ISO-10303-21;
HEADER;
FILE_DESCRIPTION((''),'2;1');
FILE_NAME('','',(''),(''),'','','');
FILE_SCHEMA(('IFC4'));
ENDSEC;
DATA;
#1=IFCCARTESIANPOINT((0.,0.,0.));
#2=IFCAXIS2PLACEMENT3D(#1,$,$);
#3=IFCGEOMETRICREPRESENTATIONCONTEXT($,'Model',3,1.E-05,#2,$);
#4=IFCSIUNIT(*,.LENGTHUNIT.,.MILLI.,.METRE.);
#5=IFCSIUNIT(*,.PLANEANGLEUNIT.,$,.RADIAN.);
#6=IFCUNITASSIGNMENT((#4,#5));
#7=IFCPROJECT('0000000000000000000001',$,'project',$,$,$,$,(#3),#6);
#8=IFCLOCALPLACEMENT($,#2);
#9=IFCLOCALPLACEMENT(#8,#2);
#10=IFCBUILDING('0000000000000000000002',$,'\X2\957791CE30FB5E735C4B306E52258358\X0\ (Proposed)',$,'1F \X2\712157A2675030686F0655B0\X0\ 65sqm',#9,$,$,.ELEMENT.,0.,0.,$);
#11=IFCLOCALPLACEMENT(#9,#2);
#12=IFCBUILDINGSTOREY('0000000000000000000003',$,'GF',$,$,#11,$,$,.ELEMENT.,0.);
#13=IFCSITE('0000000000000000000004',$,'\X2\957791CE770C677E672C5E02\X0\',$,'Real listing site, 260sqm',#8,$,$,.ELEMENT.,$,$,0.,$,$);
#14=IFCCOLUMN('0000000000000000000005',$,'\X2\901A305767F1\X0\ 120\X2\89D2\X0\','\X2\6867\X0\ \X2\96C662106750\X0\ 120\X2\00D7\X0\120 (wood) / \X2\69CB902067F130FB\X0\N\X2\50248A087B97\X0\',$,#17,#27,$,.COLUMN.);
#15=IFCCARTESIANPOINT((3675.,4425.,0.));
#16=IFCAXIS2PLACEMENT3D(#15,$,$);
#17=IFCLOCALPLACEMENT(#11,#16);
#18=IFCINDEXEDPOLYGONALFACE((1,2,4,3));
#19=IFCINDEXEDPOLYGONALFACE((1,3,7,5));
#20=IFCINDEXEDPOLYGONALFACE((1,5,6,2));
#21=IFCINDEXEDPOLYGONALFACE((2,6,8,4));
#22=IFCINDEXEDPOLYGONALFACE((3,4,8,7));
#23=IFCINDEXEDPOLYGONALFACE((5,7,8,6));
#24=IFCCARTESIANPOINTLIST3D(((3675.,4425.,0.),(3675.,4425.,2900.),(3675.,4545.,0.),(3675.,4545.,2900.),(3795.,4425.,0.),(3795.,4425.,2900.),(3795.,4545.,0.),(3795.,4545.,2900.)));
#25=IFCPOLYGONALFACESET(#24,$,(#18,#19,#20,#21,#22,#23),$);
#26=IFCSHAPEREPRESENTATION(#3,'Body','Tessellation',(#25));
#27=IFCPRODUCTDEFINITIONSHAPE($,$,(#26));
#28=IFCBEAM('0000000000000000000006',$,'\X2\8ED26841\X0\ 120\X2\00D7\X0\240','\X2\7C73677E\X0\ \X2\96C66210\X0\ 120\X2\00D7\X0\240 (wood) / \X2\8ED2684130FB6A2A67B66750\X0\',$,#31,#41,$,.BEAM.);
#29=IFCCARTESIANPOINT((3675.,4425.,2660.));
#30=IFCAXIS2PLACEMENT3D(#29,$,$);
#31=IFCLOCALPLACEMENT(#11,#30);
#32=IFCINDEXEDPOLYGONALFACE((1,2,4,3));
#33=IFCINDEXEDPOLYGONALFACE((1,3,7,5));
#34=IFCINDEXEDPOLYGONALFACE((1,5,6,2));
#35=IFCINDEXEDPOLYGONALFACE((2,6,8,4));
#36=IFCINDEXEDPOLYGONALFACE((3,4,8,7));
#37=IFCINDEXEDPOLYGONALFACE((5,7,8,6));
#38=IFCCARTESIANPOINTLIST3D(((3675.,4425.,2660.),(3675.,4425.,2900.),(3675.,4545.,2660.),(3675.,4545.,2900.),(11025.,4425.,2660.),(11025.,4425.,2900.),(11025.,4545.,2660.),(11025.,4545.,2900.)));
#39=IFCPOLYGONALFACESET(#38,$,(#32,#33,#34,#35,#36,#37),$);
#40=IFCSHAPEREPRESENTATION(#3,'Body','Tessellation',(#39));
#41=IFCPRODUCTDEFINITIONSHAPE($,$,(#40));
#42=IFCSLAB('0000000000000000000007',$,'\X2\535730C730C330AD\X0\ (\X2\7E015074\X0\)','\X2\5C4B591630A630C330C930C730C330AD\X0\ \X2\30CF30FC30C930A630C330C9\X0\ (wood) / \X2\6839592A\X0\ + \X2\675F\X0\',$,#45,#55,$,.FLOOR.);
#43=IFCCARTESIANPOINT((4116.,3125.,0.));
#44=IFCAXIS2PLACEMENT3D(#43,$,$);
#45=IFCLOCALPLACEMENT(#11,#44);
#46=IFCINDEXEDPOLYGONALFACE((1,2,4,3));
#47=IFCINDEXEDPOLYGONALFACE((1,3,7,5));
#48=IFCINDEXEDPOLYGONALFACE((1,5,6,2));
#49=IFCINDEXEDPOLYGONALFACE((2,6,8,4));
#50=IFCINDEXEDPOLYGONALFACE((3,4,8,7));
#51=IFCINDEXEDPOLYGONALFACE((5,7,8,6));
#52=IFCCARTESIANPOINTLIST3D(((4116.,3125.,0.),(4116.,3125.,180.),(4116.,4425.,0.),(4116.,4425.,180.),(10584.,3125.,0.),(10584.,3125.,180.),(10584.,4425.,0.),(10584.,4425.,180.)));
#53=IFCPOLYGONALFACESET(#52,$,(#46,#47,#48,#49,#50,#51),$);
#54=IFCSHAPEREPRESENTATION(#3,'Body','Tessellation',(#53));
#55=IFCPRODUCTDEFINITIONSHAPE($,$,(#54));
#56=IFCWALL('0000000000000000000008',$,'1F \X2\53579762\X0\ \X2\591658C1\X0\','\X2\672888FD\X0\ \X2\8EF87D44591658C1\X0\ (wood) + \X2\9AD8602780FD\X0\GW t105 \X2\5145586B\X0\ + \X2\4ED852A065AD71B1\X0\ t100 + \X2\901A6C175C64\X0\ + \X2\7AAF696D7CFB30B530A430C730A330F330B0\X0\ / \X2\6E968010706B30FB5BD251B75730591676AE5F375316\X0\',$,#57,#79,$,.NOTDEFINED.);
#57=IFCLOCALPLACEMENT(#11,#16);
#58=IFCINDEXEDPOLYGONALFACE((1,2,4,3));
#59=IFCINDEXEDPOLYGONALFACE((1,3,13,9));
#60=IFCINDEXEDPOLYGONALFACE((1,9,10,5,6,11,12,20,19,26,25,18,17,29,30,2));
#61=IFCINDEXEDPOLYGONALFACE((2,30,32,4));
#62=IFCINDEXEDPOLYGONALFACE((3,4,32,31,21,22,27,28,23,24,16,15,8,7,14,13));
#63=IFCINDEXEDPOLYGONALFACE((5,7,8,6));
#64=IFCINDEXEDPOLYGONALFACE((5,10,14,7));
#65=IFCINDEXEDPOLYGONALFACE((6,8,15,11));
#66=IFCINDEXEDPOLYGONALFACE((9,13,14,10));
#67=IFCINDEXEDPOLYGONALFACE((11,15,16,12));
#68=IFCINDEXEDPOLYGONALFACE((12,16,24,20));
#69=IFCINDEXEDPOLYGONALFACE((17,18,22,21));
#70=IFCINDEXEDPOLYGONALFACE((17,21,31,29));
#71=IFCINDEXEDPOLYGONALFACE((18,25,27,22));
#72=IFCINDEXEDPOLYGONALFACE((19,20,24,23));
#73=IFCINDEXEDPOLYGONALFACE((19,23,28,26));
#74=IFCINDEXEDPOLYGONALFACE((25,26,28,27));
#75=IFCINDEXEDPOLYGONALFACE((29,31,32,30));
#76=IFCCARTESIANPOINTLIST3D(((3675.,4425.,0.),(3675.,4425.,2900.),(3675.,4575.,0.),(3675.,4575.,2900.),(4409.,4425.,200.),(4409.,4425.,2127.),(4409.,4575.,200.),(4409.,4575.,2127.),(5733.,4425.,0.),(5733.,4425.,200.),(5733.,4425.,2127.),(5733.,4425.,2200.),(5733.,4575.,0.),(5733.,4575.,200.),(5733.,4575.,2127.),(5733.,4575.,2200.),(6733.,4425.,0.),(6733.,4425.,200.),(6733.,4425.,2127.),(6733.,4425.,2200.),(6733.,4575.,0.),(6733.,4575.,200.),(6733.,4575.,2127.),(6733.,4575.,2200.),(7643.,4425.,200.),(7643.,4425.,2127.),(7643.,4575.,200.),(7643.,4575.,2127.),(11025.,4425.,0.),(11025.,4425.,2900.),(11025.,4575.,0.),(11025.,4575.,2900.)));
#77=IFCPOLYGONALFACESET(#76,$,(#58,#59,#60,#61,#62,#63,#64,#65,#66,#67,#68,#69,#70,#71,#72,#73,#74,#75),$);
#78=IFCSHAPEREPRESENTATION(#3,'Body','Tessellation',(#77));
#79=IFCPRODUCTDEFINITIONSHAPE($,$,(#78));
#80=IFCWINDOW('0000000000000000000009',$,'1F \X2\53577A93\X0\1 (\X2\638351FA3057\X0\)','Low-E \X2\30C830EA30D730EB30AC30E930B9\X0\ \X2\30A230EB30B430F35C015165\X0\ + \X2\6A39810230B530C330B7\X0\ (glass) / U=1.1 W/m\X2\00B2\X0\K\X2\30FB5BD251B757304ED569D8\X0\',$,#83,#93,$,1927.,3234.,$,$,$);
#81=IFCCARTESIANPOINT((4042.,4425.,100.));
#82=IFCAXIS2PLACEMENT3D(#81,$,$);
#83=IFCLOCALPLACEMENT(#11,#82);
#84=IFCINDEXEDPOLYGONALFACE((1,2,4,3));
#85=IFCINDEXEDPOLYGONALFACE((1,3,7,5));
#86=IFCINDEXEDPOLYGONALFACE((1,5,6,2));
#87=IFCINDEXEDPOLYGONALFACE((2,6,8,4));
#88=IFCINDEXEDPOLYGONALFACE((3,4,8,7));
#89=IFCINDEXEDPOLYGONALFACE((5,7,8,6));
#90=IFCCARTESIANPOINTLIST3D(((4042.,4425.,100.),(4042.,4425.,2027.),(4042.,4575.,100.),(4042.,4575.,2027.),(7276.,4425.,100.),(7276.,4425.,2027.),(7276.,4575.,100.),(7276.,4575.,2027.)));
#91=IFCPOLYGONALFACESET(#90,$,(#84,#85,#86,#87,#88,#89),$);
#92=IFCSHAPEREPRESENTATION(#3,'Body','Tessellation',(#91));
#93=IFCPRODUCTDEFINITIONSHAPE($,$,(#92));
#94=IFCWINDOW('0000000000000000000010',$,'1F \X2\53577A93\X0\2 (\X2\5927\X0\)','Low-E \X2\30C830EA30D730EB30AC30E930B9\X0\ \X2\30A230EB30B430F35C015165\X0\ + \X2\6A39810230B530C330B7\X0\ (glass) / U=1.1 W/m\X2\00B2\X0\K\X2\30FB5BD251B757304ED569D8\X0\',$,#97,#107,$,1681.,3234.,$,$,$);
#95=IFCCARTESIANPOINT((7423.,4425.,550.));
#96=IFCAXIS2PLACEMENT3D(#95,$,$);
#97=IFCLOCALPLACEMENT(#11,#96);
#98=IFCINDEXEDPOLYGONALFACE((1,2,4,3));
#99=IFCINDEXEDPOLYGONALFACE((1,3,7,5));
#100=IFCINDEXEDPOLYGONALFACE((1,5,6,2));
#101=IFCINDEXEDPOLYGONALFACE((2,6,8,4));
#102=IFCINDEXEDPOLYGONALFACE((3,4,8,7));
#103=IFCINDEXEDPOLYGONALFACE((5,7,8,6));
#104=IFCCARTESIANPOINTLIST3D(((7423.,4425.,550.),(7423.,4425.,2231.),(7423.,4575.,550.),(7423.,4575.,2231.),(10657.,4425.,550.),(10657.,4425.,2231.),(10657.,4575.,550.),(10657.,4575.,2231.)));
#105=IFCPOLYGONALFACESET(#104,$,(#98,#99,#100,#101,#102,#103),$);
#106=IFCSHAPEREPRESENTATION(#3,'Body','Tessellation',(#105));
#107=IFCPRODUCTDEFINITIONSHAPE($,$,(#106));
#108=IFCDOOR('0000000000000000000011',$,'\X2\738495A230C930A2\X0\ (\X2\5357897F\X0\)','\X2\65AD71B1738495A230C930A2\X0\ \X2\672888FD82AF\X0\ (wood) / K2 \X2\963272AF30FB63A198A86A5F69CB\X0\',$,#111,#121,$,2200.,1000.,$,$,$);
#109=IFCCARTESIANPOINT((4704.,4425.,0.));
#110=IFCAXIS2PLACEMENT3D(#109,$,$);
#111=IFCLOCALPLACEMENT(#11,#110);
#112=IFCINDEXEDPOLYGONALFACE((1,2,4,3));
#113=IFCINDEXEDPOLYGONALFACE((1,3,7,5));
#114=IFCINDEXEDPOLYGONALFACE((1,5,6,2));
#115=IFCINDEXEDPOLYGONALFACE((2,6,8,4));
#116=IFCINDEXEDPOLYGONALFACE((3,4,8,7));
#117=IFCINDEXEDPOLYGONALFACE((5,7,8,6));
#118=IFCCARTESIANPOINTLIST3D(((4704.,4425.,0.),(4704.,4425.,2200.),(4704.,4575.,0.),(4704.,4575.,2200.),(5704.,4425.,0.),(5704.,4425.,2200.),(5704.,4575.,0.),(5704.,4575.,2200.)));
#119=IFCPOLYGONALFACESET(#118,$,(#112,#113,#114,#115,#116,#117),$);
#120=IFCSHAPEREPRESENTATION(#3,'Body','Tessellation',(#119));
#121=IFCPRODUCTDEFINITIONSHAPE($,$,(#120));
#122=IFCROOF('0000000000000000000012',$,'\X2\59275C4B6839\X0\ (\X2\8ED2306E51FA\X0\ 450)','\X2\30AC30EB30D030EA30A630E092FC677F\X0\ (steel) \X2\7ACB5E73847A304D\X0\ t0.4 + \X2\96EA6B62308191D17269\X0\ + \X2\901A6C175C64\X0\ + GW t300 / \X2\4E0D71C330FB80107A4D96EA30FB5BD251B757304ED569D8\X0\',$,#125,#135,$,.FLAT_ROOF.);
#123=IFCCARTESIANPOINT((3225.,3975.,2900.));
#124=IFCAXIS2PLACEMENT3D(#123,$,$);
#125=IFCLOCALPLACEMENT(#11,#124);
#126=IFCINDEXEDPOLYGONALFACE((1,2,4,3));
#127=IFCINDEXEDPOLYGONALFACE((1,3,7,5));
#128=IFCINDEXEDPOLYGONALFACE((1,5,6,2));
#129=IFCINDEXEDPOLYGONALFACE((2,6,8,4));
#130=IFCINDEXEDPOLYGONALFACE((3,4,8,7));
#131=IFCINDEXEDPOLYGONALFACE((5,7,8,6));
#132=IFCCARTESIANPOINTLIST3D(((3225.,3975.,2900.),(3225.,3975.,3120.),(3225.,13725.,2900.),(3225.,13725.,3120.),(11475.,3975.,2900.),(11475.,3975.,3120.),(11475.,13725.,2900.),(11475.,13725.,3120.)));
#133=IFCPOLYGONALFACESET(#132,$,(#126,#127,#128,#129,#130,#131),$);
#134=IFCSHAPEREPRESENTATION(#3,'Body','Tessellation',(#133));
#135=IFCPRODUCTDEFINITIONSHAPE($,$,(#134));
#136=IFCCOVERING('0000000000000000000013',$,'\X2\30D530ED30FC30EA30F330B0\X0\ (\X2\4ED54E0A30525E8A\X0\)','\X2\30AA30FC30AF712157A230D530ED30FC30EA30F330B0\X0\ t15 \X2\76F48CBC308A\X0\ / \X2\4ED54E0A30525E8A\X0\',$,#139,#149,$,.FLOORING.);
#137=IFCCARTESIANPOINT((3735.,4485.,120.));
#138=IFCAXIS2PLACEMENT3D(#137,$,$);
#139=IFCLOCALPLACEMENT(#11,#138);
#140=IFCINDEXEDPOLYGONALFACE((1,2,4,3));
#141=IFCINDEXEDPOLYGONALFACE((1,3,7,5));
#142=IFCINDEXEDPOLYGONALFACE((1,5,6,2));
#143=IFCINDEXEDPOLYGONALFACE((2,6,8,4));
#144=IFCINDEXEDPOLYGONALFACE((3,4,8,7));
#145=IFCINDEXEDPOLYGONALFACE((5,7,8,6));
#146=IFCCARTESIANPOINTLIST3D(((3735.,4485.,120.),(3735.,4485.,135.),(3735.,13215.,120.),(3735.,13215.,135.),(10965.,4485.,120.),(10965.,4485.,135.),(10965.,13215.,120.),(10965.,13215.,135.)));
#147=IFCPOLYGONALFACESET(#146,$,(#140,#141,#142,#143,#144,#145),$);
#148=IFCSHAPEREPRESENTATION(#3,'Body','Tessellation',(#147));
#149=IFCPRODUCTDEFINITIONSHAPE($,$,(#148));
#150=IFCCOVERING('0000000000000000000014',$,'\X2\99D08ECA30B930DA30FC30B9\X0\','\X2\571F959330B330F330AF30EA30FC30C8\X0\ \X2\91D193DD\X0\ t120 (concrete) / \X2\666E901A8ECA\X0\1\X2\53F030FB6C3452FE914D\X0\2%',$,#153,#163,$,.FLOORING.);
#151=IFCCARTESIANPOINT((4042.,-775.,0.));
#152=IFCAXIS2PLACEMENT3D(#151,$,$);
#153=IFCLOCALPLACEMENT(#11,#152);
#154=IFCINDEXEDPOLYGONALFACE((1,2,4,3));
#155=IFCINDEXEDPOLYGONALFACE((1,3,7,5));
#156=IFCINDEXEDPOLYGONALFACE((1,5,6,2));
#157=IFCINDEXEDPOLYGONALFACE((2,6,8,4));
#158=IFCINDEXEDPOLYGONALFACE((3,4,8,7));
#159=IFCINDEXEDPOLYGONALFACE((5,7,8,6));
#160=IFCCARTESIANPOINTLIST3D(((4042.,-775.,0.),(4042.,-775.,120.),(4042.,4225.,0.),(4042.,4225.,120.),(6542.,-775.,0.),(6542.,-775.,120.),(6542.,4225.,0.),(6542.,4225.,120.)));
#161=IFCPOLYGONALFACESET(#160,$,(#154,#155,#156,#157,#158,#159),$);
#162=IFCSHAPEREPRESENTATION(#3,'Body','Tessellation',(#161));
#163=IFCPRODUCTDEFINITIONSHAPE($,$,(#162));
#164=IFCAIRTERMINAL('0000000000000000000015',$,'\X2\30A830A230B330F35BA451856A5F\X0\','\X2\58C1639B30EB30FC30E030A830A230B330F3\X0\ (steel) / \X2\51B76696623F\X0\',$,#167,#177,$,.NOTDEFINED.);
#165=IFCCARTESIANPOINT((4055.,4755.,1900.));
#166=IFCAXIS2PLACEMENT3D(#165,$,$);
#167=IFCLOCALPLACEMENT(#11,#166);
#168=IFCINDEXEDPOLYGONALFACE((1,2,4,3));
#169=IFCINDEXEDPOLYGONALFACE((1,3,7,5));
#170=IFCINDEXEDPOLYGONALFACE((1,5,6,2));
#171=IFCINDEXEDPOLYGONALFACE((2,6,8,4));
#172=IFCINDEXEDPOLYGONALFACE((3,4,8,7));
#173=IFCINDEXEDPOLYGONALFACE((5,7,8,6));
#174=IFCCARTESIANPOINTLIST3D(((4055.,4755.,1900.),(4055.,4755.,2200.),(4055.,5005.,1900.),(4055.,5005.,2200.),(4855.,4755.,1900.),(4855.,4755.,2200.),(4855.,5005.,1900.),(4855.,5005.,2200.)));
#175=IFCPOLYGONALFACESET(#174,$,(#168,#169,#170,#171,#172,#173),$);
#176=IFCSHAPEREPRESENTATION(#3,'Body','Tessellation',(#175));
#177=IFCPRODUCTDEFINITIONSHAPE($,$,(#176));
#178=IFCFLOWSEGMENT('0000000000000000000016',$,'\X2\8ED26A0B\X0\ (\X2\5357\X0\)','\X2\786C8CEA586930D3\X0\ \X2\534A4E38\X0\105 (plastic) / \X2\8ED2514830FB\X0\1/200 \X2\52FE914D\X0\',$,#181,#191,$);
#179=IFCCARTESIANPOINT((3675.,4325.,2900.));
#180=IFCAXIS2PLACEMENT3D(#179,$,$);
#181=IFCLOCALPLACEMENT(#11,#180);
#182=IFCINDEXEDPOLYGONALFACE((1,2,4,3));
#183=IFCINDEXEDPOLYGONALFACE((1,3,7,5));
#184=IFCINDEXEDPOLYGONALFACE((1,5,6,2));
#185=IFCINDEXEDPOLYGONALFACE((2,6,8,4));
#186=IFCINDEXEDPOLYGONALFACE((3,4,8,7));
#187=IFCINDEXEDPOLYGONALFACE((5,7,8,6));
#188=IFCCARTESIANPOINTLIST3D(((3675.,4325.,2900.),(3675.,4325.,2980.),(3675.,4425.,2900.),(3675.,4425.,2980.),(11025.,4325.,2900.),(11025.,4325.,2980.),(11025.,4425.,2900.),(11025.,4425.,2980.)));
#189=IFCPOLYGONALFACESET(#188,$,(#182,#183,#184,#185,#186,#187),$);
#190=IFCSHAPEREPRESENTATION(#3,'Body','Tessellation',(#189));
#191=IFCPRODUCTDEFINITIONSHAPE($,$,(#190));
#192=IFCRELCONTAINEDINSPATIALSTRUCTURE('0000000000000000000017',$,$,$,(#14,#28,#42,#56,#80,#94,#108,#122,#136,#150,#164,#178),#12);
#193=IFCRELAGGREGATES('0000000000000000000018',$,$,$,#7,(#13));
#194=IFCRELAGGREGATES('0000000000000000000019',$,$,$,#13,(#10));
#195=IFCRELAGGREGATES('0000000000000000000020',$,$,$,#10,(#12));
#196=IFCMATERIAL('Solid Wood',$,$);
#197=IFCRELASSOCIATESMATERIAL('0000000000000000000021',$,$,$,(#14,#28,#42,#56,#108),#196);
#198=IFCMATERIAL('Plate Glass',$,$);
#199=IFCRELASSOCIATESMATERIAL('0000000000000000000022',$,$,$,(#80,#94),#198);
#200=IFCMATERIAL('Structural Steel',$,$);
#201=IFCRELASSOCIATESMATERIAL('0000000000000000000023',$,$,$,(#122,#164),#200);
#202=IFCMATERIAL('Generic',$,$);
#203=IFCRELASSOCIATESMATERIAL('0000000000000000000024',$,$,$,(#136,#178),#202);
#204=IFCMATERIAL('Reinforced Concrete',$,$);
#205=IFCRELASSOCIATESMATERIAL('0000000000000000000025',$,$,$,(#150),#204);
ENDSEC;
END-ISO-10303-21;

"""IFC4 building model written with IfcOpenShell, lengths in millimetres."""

from ifc_helpers import new_model, si_unit, frame, frame_2d, origin, place, context, project, spatial, rectangle, extrude, material, element, fill, save


model = new_model("IFC4")

# Units and contexts
model_context = context("Model", 3, precision=1e-05, world=origin())
ifc_project = project(units=[si_unit("LENGTHUNIT", "METRE", prefix="MILLI"), si_unit("PLANEANGLEUNIT", "RADIAN")], contexts=[model_context])

# Site, building, storey
site_placement = place(None, origin())
site = spatial("IfcSite", under=ifc_project, at=site_placement, Name="長野県松本市", ObjectType="Real listing site, 260sqm", CompositionType="ELEMENT", RefElevation=0.0)
building_placement = place(site_placement, origin())
building = spatial("IfcBuilding", under=site, at=building_placement, Name="長野・平屋の別荘 (Proposed)", ObjectType="1F 無垢材と漆喰 65sqm", CompositionType="ELEMENT", ElevationOfRefHeight=0.0, ElevationOfTerrain=0.0)
storey_placement = place(building_placement, origin())
storey = spatial("IfcBuildingStorey", under=building, at=storey_placement, Name="GF", CompositionType="ELEMENT", Elevation=0.0)

# Column
ifc_material_1 = material(Name="Solid Wood")
column_1_placement = place(storey_placement, frame((3675.0, 4425.0, 0.0)))
element("IfcColumn", 1, at=column_1_placement, inside=storey, material=ifc_material_1, Name="通し柱 120角", Description="桧 集成材 120×120 (wood) / 構造柱・N値計算", PredefinedType="COLUMN", context=model_context, shape_type="SweptSolid", body=[
    extrude(rectangle(XDim=120.0, YDim=120.0, at=frame_2d((60.0, 60.0))), frame((3675.0, 4425.0, 0.0)), (0.0, 0.0, 1.0), 2900.0),
])

# Beam
beam_1_placement = place(storey_placement, frame((3675.0, 4425.0, 2660.0)))
element("IfcBeam", 2, at=beam_1_placement, inside=storey, material=ifc_material_1, Name="軒桁 120×240", Description="米松 集成 120×240 (wood) / 軒桁・横架材", PredefinedType="BEAM", context=model_context, shape_type="SweptSolid", body=[
    extrude(rectangle(XDim=7350.0, YDim=120.0, at=frame_2d((3675.0, 60.0))), frame((3675.0, 4425.0, 2660.0)), (0.0, 0.0, 1.0), 240.0),
])

# Slab
ifc_material_2 = material(Name="Reinforced Concrete")
slab_1_placement = place(storey_placement, frame((4116.0, 3125.0, 0.0)))
element("IfcSlab", 3, at=slab_1_placement, inside=storey, material=ifc_material_1, Name="南デッキ (縁側)", Description="屋外ウッドデッキ ハードウッド (wood) / 根太 + 束", PredefinedType="FLOOR", context=model_context, shape_type="SweptSolid", body=[
    extrude(rectangle(XDim=6468.0, YDim=1300.0, at=frame_2d((3234.0, 650.0))), frame((4116.0, 3125.0, 0.0)), (0.0, 0.0, 1.0), 180.0),
])

# Wall, openings, windows, door
wall_1_placement = place(storey_placement, frame((3675.0, 4425.0, 0.0)))
wall_1 = element("IfcWall", 4, at=wall_1_placement, inside=storey, material=ifc_material_1, Name="1F 南面 外壁", Description="木製 軸組外壁 (wood) + 高性能GW t105 充填 + 付加断熱 t100 + 通気層 + 窯業系サイディング / 準耐火・寒冷地外皮強化", PredefinedType="NOTDEFINED", context=model_context, shape_type="SweptSolid", body=[
    extrude(rectangle(XDim=7350.0, YDim=150.0, at=frame_2d((3675.0, 75.0))), frame((3675.0, 4425.0, 0.0)), (0.0, 0.0, 1.0), 2900.0),
])
opening_1_placement = place(storey_placement, frame((4042.0, 4425.0, 100.0)))
opening_1 = element("IfcOpeningElement", 5, at=opening_1_placement, cuts=wall_1, PredefinedType="NOTDEFINED", context=model_context, shape_type="SweptSolid", body=[
    extrude(rectangle(XDim=3234.0, YDim=150.0, at=frame_2d((1617.0, 75.0))), frame((4042.0, 4425.0, 100.0)), (0.0, 0.0, 1.0), 1927.0),
])
opening_2_placement = place(storey_placement, frame((7423.0, 4425.0, 550.0)))
opening_2 = element("IfcOpeningElement", 6, at=opening_2_placement, cuts=wall_1, PredefinedType="NOTDEFINED", context=model_context, shape_type="SweptSolid", body=[
    extrude(rectangle(XDim=3234.0, YDim=150.0, at=frame_2d((1617.0, 75.0))), frame((7423.0, 4425.0, 550.0)), (0.0, 0.0, 1.0), 1681.0),
])
opening_3_placement = place(storey_placement, frame((4704.0, 4425.0, 0.0)))
opening_3 = element("IfcOpeningElement", 7, at=opening_3_placement, cuts=wall_1, PredefinedType="NOTDEFINED", context=model_context, shape_type="SweptSolid", body=[
    extrude(rectangle(XDim=1000.0, YDim=150.0, at=frame_2d((500.0, 75.0))), frame((4704.0, 4425.0, 0.0)), (0.0, 0.0, 1.0), 2200.0),
])
ifc_material_3 = material(Name="Plate Glass")
window_1_placement = place(storey_placement, frame((4042.0, 4425.0, 100.0)))
window_1 = element("IfcWindow", 8, at=window_1_placement, inside=storey, material=ifc_material_3, Name="1F 南窓1 (掃出し)", Description="Low-E トリプルガラス アルゴン封入 + 樹脂サッシ (glass) / U=1.1 W/m²K・寒冷地仕様", OverallHeight=1927.0, OverallWidth=3234.0, context=model_context, shape_type="SweptSolid", body=[
    extrude(rectangle(XDim=3234.0, YDim=150.0, at=frame_2d((1617.0, 75.0))), frame((4042.0, 4425.0, 100.0)), (0.0, 0.0, 1.0), 1927.0),
])
fill(opening_1, window_1)
window_2_placement = place(storey_placement, frame((7423.0, 4425.0, 550.0)))
window_2 = element("IfcWindow", 9, at=window_2_placement, inside=storey, material=ifc_material_3, Name="1F 南窓2 (大)", Description="Low-E トリプルガラス アルゴン封入 + 樹脂サッシ (glass) / U=1.1 W/m²K・寒冷地仕様", OverallHeight=1681.0, OverallWidth=3234.0, context=model_context, shape_type="SweptSolid", body=[
    extrude(rectangle(XDim=3234.0, YDim=150.0, at=frame_2d((1617.0, 75.0))), frame((7423.0, 4425.0, 550.0)), (0.0, 0.0, 1.0), 1681.0),
])
fill(opening_2, window_2)
door_placement = place(storey_placement, frame((4704.0, 4425.0, 0.0)))
door = element("IfcDoor", 10, at=door_placement, inside=storey, material=ifc_material_1, Name="玄関ドア (南西)", Description="断熱玄関ドア 木製芯 (wood) / K2 防犯・採風機構", OverallHeight=2200.0, OverallWidth=1000.0, context=model_context, shape_type="SweptSolid", body=[
    extrude(rectangle(XDim=1000.0, YDim=150.0, at=frame_2d((500.0, 75.0))), frame((4704.0, 4425.0, 0.0)), (0.0, 0.0, 1.0), 2200.0),
])
fill(opening_3, door)

# Roof
ifc_material_4 = material(Name="Structural Steel")
roof_placement = place(storey_placement, frame((3225.0, 3975.0, 2900.0)))
element("IfcRoof", 11, at=roof_placement, inside=storey, material=ifc_material_4, Name="大屋根 (軒の出 450)", Description="ガルバリウム鋼板 (steel) 立平葺き t0.4 + 雪止め金物 + 通気層 + GW t300 / 不燃・耐積雪・寒冷地仕様", PredefinedType="FLAT_ROOF", context=model_context, shape_type="SweptSolid", body=[
    extrude(rectangle(XDim=8250.0, YDim=9750.0, at=frame_2d((4125.0, 4875.0))), frame((3225.0, 3975.0, 2900.0)), (0.0, 0.0, 1.0), 220.0),
])

# Coverings
ifc_material_5 = material(Name="Generic")
covering_1_placement = place(storey_placement, frame((3735.0, 4485.0, 120.0)))
element("IfcCovering", 12, at=covering_1_placement, inside=storey, material=ifc_material_5, Name="フローリング (仕上げ床)", Description="オーク無垢フローリング t15 直貼り / 仕上げ床", PredefinedType="FLOORING", context=model_context, shape_type="SweptSolid", body=[
    extrude(rectangle(XDim=7230.0, YDim=8730.0, at=frame_2d((3615.0, 4365.0))), frame((3735.0, 4485.0, 120.0)), (0.0, 0.0, 1.0), 15.0),
])
covering_2_placement = place(storey_placement, frame((4042.0, -775.0, 0.0)))
element("IfcCovering", 13, at=covering_2_placement, inside=storey, material=ifc_material_2, Name="駐車スペース", Description="土間コンクリート 金鏝 t120 (concrete) / 普通車1台・水勾配2%", PredefinedType="FLOORING", context=model_context, shape_type="SweptSolid", body=[
    extrude(rectangle(XDim=2500.0, YDim=5000.0, at=frame_2d((1250.0, 2500.0))), frame((4042.0, -775.0, 0.0)), (0.0, 0.0, 1.0), 120.0),
])

# Air terminal
air_terminal_placement = place(storey_placement, frame((4055.0, 4755.0, 1900.0)))
element("IfcAirTerminal", 14, at=air_terminal_placement, inside=storey, material=ifc_material_4, Name="エアコン室内機", Description="壁掛ルームエアコン (steel) / 冷暖房", PredefinedType="NOTDEFINED", context=model_context, shape_type="SweptSolid", body=[
    extrude(rectangle(XDim=800.0, YDim=250.0, at=frame_2d((400.0, 125.0))), frame((4055.0, 4755.0, 1900.0)), (0.0, 0.0, 1.0), 300.0),
])

# Flow segment
flow_segment_1_placement = place(storey_placement, frame((3675.0, 4325.0, 2900.0)))
element("IfcFlowSegment", 15, at=flow_segment_1_placement, inside=storey, material=ifc_material_5, Name="軒樋 (南)", Description="硬質塩ビ 半丸105 (plastic) / 軒先・1/200 勾配", context=model_context, shape_type="SweptSolid", body=[
    extrude(rectangle(XDim=7350.0, YDim=100.0, at=frame_2d((3675.0, 50.0))), frame((3675.0, 4325.0, 2900.0)), (0.0, 0.0, 1.0), 80.0),
])

save(model, "model.ifc")
